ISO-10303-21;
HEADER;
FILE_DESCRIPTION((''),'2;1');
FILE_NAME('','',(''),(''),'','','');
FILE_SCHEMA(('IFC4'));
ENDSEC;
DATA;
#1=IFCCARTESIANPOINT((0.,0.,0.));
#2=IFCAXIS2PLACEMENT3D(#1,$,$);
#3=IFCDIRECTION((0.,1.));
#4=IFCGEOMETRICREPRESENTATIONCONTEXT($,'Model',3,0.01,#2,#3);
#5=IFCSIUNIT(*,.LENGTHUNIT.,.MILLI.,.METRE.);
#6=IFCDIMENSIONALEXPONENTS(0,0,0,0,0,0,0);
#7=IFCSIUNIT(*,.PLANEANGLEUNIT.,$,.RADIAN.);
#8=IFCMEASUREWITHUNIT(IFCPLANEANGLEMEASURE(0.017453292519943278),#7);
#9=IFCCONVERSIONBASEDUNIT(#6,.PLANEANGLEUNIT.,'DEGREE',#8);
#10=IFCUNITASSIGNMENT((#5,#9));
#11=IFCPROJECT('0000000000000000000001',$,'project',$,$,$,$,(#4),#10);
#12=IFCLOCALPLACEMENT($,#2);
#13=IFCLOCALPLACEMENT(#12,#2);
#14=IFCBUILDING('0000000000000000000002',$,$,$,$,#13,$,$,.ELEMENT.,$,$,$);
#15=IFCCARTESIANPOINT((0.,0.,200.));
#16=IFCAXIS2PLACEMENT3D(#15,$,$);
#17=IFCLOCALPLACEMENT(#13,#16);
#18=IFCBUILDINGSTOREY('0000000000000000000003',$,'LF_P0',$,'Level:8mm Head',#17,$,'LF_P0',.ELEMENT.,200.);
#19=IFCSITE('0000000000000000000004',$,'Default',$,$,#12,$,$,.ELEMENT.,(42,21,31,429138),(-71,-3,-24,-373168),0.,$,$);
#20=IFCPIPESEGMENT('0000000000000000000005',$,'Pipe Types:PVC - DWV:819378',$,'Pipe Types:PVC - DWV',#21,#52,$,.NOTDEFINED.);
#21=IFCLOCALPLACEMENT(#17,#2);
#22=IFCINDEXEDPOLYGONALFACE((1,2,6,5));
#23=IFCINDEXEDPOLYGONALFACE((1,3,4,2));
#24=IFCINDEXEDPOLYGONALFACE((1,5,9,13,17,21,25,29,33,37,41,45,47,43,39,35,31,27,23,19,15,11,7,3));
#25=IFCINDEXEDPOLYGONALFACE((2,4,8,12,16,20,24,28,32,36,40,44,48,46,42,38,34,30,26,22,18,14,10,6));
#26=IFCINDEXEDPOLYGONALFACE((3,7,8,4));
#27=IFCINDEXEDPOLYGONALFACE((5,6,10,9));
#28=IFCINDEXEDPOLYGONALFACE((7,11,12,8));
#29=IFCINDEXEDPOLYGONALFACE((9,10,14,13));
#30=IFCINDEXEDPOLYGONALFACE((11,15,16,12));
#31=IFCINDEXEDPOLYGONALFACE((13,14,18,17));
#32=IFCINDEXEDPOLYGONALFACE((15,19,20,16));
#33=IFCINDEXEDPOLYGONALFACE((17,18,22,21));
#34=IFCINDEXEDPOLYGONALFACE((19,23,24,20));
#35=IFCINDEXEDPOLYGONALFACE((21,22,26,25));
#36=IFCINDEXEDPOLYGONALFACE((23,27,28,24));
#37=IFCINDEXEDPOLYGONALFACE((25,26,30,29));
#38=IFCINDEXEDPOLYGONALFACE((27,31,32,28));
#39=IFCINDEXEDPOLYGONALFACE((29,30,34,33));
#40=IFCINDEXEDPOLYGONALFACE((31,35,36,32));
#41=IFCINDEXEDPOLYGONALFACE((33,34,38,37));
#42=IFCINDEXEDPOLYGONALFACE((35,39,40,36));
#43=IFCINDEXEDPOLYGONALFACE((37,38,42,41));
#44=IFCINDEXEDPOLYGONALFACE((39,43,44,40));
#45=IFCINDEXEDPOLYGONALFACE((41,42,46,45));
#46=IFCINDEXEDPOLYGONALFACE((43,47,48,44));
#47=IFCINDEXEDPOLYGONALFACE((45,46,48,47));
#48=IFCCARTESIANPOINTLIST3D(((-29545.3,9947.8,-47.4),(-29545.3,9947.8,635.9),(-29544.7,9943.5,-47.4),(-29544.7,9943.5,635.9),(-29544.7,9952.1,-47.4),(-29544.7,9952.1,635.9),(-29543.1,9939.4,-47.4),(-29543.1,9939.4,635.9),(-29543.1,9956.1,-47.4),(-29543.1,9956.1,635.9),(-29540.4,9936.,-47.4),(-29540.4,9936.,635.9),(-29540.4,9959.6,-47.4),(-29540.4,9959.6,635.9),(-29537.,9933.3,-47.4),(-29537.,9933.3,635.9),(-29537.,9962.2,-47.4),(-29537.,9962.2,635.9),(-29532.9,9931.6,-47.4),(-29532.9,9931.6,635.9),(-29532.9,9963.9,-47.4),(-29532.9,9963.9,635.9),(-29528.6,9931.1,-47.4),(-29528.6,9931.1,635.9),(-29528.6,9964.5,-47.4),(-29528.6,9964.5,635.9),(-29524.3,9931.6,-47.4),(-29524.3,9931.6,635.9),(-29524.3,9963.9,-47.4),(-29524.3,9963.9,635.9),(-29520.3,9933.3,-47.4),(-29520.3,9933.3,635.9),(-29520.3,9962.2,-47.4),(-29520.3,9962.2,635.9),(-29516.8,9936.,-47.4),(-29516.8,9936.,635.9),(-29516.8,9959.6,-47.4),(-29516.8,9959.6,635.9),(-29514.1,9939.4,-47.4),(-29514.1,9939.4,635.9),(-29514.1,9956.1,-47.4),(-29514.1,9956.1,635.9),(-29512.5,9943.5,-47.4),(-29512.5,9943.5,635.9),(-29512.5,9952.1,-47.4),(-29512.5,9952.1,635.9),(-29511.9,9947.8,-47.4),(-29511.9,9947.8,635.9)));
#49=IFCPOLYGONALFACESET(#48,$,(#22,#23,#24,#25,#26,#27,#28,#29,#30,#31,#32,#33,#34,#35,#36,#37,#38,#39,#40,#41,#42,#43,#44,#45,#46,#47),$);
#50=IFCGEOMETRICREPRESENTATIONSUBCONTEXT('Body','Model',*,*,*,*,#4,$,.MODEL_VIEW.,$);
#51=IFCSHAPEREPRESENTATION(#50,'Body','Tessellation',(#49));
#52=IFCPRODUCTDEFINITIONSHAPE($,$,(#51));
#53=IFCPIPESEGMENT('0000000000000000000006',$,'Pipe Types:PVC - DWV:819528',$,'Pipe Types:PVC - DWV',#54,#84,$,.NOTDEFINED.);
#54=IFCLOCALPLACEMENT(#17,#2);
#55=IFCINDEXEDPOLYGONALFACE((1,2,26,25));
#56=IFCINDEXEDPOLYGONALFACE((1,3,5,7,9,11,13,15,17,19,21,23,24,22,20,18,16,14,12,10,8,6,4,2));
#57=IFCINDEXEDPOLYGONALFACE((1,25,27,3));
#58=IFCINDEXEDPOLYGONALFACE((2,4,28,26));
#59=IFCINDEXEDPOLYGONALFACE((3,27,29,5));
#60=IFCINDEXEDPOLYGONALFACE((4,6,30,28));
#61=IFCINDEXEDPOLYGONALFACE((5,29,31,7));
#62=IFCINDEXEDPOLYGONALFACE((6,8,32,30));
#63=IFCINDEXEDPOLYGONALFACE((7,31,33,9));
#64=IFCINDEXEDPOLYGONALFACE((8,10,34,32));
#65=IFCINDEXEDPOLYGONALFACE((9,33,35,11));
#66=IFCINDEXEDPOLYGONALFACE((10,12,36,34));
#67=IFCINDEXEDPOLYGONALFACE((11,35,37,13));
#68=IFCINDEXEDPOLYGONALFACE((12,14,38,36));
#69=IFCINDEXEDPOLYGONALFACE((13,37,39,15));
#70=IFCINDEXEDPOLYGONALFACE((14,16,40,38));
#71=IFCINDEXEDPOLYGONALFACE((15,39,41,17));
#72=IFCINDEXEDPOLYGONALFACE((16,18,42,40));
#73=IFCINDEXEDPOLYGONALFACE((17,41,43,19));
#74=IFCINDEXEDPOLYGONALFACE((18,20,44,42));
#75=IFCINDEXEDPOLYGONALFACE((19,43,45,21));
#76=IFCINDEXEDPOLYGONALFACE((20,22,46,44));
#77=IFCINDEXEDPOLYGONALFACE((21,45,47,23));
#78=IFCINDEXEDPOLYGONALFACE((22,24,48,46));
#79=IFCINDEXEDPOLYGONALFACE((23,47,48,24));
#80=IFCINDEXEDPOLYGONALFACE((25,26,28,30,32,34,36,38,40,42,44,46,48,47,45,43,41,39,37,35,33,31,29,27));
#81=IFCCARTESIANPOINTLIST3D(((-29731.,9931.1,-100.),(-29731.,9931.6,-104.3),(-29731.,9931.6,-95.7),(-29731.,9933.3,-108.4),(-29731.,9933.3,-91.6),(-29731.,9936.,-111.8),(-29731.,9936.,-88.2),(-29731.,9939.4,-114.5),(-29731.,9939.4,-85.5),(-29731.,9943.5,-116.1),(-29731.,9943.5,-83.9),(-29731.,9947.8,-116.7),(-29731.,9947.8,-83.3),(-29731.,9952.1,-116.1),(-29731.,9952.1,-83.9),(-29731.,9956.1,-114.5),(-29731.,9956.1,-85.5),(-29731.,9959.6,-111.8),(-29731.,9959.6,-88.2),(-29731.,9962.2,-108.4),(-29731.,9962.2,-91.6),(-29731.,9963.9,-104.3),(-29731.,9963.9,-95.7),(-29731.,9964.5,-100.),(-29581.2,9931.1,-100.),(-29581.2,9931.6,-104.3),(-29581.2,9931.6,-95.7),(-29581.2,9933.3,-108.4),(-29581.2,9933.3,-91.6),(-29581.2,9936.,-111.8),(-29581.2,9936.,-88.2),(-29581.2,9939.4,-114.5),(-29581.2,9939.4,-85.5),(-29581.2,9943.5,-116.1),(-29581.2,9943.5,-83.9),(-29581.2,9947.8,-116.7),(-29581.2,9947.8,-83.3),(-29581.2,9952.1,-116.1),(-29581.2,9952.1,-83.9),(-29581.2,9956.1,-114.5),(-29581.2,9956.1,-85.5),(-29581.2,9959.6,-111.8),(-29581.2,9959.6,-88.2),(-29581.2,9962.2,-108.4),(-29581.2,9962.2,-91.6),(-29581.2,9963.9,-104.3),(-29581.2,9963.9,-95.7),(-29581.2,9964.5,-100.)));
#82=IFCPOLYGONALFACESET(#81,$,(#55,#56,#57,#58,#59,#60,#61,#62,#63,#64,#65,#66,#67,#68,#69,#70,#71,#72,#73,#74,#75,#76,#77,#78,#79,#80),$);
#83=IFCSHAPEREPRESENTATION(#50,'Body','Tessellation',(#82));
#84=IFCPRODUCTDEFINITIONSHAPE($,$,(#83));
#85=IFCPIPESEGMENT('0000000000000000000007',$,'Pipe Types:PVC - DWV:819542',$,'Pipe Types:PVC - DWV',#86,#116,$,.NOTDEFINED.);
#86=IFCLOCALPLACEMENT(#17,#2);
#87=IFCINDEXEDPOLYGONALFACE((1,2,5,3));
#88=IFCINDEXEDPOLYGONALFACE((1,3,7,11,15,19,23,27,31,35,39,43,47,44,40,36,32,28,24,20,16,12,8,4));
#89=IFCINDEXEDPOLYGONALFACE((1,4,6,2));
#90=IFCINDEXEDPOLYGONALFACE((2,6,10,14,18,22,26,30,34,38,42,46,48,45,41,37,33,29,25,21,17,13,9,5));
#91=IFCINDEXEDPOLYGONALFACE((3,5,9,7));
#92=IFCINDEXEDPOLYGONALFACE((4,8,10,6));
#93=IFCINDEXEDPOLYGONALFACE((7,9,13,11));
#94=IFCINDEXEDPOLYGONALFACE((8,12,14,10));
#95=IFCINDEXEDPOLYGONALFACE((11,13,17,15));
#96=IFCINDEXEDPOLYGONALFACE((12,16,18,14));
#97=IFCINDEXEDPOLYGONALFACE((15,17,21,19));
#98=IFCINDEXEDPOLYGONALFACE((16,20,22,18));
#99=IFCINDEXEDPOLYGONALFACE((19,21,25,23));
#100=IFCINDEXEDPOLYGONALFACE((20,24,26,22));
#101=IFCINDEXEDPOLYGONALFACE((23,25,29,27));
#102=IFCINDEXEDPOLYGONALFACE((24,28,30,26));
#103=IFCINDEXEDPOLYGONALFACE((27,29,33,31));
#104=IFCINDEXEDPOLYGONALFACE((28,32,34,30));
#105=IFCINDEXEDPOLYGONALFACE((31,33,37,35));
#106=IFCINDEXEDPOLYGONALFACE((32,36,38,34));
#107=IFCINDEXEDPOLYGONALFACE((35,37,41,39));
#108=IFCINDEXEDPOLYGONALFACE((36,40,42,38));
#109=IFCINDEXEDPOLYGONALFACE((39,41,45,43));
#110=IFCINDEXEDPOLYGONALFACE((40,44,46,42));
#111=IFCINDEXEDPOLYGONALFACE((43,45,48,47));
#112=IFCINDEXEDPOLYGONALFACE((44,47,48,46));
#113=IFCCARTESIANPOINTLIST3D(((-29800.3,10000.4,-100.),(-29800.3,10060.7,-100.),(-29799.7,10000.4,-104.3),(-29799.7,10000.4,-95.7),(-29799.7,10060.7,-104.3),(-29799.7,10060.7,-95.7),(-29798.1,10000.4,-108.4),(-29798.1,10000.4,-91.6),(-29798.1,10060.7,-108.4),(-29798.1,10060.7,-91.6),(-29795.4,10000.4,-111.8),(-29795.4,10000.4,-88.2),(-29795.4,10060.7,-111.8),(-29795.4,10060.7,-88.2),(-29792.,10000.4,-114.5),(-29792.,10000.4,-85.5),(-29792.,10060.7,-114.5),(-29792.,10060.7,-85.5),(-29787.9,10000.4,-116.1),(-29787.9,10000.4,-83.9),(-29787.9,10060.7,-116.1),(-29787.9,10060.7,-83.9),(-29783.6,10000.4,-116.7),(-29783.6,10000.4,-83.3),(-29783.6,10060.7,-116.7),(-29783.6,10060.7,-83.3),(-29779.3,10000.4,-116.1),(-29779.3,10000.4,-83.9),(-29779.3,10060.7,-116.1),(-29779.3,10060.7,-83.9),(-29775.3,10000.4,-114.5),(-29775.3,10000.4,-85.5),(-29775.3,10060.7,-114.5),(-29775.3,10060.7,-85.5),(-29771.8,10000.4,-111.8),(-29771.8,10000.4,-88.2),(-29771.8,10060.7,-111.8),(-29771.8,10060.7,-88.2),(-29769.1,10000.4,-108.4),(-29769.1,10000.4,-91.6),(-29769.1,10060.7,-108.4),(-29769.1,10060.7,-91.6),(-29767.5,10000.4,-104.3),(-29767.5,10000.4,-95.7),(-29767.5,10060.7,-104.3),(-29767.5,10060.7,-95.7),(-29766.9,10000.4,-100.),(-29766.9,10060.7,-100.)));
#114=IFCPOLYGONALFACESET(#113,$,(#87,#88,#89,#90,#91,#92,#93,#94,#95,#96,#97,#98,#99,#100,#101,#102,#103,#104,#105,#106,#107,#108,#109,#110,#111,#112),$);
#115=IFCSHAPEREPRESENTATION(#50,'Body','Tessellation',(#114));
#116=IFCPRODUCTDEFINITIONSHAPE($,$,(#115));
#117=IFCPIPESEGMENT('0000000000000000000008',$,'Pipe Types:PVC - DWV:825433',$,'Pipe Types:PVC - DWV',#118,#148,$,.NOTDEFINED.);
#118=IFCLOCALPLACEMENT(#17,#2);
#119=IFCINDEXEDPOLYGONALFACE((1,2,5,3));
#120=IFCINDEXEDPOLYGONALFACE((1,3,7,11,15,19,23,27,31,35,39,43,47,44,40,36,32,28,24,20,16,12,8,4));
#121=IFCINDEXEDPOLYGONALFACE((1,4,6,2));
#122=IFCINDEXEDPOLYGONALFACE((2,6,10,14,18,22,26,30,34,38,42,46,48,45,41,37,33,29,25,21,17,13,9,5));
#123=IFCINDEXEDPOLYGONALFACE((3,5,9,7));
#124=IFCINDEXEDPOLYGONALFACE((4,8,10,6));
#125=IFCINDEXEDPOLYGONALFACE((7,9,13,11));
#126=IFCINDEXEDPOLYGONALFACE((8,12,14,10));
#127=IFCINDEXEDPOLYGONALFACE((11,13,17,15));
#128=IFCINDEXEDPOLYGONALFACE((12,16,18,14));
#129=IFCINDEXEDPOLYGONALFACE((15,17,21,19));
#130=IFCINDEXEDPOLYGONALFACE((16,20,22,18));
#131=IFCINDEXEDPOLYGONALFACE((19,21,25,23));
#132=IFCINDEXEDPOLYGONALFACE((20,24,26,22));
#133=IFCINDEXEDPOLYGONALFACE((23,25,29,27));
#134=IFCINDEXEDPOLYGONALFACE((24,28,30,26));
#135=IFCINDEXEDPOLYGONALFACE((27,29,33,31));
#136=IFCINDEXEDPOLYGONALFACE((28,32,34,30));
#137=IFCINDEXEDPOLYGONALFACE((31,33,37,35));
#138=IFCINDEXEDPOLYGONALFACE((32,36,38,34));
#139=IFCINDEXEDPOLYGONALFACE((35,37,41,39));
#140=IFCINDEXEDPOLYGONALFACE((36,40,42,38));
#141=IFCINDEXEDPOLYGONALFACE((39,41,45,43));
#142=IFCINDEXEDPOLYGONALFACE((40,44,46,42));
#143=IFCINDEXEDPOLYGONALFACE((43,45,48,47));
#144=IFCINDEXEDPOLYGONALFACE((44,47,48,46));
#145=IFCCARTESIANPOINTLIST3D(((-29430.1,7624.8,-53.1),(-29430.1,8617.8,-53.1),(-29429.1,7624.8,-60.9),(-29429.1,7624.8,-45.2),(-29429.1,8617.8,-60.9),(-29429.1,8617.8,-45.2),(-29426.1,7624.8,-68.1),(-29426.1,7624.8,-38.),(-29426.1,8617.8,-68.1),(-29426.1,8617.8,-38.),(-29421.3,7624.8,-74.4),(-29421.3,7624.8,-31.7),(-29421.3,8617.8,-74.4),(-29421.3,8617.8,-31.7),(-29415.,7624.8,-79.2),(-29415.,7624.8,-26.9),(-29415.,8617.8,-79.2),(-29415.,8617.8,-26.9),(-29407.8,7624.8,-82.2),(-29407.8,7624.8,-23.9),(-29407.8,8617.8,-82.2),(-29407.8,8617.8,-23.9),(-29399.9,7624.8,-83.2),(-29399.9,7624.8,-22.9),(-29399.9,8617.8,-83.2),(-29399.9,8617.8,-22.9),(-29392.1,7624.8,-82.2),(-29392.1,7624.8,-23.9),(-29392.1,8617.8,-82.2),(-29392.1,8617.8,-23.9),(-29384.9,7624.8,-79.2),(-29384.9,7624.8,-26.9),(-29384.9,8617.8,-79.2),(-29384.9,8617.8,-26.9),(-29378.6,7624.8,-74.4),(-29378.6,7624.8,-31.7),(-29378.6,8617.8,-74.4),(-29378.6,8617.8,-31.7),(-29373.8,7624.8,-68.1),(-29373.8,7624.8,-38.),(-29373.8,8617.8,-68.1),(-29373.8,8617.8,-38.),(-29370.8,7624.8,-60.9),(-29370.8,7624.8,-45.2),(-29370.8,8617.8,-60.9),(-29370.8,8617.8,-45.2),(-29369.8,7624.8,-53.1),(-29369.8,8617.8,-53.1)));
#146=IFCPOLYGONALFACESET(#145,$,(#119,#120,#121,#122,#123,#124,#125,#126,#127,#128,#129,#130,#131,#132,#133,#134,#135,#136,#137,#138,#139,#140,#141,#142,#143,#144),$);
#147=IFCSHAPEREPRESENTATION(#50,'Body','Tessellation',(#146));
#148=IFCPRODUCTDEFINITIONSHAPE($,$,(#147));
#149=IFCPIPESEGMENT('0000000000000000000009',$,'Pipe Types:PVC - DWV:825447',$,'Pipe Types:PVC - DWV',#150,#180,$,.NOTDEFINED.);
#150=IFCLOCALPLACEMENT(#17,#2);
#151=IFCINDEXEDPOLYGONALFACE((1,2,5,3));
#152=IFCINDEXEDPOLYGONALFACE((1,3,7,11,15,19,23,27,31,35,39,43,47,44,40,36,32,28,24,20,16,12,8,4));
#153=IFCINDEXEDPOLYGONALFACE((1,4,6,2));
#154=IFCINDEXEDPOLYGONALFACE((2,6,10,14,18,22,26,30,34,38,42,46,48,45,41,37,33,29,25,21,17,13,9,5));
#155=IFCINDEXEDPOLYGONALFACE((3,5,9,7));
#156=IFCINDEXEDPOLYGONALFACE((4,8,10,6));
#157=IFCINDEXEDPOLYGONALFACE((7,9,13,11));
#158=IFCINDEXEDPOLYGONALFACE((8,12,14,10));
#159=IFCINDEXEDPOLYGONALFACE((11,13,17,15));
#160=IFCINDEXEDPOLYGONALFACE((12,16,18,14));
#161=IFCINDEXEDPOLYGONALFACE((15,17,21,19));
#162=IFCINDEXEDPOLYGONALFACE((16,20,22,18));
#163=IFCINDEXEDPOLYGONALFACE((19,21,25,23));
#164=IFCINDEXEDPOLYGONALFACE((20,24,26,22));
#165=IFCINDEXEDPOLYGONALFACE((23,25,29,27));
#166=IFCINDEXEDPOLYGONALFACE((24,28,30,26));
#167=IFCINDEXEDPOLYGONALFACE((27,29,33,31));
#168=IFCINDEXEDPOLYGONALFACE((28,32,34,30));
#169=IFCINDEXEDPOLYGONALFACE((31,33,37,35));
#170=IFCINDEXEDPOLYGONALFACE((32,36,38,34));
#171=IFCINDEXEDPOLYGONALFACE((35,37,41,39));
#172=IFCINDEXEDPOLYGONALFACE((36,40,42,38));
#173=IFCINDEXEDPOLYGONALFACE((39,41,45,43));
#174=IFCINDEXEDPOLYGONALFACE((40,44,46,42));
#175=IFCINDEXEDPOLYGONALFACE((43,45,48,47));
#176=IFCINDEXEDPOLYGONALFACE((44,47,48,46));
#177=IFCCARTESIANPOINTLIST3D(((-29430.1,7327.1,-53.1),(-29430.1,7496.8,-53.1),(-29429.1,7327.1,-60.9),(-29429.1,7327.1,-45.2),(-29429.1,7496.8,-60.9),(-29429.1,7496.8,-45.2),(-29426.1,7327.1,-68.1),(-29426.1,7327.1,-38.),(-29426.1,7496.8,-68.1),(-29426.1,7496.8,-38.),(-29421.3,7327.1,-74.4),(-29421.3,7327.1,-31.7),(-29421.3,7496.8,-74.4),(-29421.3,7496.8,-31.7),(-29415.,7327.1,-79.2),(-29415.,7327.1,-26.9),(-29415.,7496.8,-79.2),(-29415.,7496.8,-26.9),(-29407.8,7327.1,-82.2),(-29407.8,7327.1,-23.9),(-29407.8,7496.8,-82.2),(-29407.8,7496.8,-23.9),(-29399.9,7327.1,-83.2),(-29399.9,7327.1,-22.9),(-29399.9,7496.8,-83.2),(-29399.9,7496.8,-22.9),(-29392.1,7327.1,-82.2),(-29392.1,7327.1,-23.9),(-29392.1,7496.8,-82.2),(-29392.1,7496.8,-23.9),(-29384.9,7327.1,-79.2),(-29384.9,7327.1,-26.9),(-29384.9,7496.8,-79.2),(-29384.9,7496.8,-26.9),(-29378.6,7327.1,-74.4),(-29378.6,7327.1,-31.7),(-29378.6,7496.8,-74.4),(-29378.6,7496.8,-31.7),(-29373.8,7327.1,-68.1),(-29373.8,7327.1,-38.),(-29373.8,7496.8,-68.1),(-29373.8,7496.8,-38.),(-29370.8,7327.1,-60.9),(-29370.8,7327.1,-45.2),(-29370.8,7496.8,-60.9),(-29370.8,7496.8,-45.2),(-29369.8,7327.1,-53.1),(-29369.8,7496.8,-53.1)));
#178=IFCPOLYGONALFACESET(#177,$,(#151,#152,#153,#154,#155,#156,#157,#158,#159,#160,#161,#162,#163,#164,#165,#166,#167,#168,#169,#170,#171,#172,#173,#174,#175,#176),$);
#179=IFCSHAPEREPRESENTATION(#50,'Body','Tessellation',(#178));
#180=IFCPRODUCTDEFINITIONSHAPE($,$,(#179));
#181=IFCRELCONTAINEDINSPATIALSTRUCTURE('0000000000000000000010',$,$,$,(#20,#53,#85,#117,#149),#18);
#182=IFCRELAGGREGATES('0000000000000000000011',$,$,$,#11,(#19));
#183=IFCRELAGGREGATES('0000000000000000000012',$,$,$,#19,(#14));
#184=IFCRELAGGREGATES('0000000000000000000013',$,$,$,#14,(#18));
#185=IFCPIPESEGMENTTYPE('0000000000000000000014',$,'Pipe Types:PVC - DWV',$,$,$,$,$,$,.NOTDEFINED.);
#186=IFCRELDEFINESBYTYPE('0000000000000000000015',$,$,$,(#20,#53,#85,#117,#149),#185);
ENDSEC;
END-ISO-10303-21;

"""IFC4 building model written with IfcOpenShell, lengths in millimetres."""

from ifc_helpers import new_model, entity, si_unit, converted_unit, direction, frame, origin, place, context, subcontext, project, spatial, arc, indexed_curve, outline, extrude, type_object, element, save


model = new_model("IFC4")

# Units and contexts
model_context = context("Model", 3, precision=0.01, world=origin(), true_north=direction((0.0, 1.0)))
body_context = subcontext(model_context, "Body", "Model", "MODEL_VIEW")
ifc_project = project(units=[si_unit("LENGTHUNIT", "METRE", prefix="MILLI"), converted_unit("PLANEANGLEUNIT", "DEGREE", entity("IfcPlaneAngleMeasure", 0.017453292519943278), si_unit("PLANEANGLEUNIT", "RADIAN"), dimensions=[0, 0, 0, 0, 0, 0, 0])], contexts=[model_context])

# Site, building, storey
site_placement = place(None, origin())
site = spatial("IfcSite", under=ifc_project, at=site_placement, Name="Default", CompositionType="ELEMENT", RefLatitude=(42, 21, 31, 429138), RefLongitude=(-71, -3, -24, -373168), RefElevation=0.0)
building_placement = place(site_placement, origin())
building = spatial("IfcBuilding", under=site, at=building_placement, CompositionType="ELEMENT")
storey_placement = place(building_placement, frame((0.0, 0.0, 200.0)))
storey = spatial("IfcBuildingStorey", under=building, at=storey_placement, Name="LF_P0", ObjectType="Level:8mm Head", LongName="LF_P0", CompositionType="ELEMENT", Elevation=200.0)

# Pipe segments
pipe_segment_type_1 = type_object("IfcPipeSegmentType", Name="Pipe Types:PVC - DWV", PredefinedType="NOTDEFINED")
pipe_segment_1_placement = place(storey_placement, origin())
element("IfcPipeSegment", 1, at=pipe_segment_1_placement, inside=storey, type_object=pipe_segment_type_1, Name="Pipe Types:PVC - DWV:819378", ObjectType="Pipe Types:PVC - DWV", PredefinedType="NOTDEFINED", context=body_context, shape_type="SweptSolid", body=[
    extrude(outline(indexed_curve([(16.7, 0.0), (11.8, 11.8), (0.0, 16.7), (-11.8, 11.8), (-16.7, 0.0), (-11.8, -11.8), (0.0, -16.7), (11.8, -11.8)], segments=[arc(1, 2, 3), arc(3, 4, 5), arc(5, 6, 7), arc(7, 8, 1)], self_intersect=False)), frame((-29528.6, 9947.8, -47.4)), (0.0, 0.0, 1.0), 683.3),
])
pipe_segment_2_placement = place(storey_placement, origin())
element("IfcPipeSegment", 2, at=pipe_segment_2_placement, inside=storey, type_object=pipe_segment_type_1, Name="Pipe Types:PVC - DWV:819528", ObjectType="Pipe Types:PVC - DWV", PredefinedType="NOTDEFINED", context=body_context, shape_type="SweptSolid", body=[
    extrude(outline(indexed_curve([(16.7, 0.0), (11.8, 11.8), (0.0, 16.7), (-11.8, 11.8), (-16.7, 0.0), (-11.8, -11.8), (0.0, -16.7), (11.8, -11.8)], segments=[arc(1, 2, 3), arc(3, 4, 5), arc(5, 6, 7), arc(7, 8, 1)], self_intersect=False)), frame((-29731.0, 9947.8, -100.0), z_axis=(1.0, 0.0, 0.0), x_axis=(0.0, 1.0, 0.0)), (0.0, 0.0, 1.0), 149.8),
])
pipe_segment_3_placement = place(storey_placement, origin())
element("IfcPipeSegment", 3, at=pipe_segment_3_placement, inside=storey, type_object=pipe_segment_type_1, Name="Pipe Types:PVC - DWV:819542", ObjectType="Pipe Types:PVC - DWV", PredefinedType="NOTDEFINED", context=body_context, shape_type="SweptSolid", body=[
    extrude(outline(indexed_curve([(16.7, 0.0), (11.8, 11.8), (0.0, 16.7), (-11.8, 11.8), (-16.7, 0.0), (-11.8, -11.8), (0.0, -16.7), (11.8, -11.8)], segments=[arc(1, 2, 3), arc(3, 4, 5), arc(5, 6, 7), arc(7, 8, 1)], self_intersect=False)), frame((-29783.6, 10000.4, -100.0), z_axis=(0.0, 1.0, 0.0), x_axis=(1.0, 0.0, 0.0)), (0.0, 0.0, 1.0), 60.3),
])
pipe_segment_4_placement = place(storey_placement, origin())
element("IfcPipeSegment", 4, at=pipe_segment_4_placement, inside=storey, type_object=pipe_segment_type_1, Name="Pipe Types:PVC - DWV:825433", ObjectType="Pipe Types:PVC - DWV", PredefinedType="NOTDEFINED", context=body_context, shape_type="SweptSolid", body=[
    extrude(outline(indexed_curve([(30.2, 0.0), (21.3, 21.3), (0.0, 30.2), (-21.3, 21.3), (-30.2, 0.0), (-21.3, -21.3), (0.0, -30.2), (21.3, -21.3)], segments=[arc(1, 2, 3), arc(3, 4, 5), arc(5, 6, 7), arc(7, 8, 1)], self_intersect=False)), frame((-29399.9, 7624.8, -53.1), z_axis=(0.0, 1.0, 0.0), x_axis=(1.0, 0.0, 0.0)), (0.0, 0.0, 1.0), 993.0),
])
pipe_segment_5_placement = place(storey_placement, origin())
element("IfcPipeSegment", 5, at=pipe_segment_5_placement, inside=storey, type_object=pipe_segment_type_1, Name="Pipe Types:PVC - DWV:825447", ObjectType="Pipe Types:PVC - DWV", PredefinedType="NOTDEFINED", context=body_context, shape_type="SweptSolid", body=[
    extrude(outline(indexed_curve([(30.2, 0.0), (21.3, 21.3), (0.0, 30.2), (-21.3, 21.3), (-30.2, 0.0), (-21.3, -21.3), (0.0, -30.2), (21.3, -21.3)], segments=[arc(1, 2, 3), arc(3, 4, 5), arc(5, 6, 7), arc(7, 8, 1)], self_intersect=False)), frame((-29399.9, 7327.1, -53.1), z_axis=(0.0, 1.0, 0.0), x_axis=(1.0, 0.0, 0.0)), (0.0, 0.0, 1.0), 169.7),
])

save(model, "model.ifc")
